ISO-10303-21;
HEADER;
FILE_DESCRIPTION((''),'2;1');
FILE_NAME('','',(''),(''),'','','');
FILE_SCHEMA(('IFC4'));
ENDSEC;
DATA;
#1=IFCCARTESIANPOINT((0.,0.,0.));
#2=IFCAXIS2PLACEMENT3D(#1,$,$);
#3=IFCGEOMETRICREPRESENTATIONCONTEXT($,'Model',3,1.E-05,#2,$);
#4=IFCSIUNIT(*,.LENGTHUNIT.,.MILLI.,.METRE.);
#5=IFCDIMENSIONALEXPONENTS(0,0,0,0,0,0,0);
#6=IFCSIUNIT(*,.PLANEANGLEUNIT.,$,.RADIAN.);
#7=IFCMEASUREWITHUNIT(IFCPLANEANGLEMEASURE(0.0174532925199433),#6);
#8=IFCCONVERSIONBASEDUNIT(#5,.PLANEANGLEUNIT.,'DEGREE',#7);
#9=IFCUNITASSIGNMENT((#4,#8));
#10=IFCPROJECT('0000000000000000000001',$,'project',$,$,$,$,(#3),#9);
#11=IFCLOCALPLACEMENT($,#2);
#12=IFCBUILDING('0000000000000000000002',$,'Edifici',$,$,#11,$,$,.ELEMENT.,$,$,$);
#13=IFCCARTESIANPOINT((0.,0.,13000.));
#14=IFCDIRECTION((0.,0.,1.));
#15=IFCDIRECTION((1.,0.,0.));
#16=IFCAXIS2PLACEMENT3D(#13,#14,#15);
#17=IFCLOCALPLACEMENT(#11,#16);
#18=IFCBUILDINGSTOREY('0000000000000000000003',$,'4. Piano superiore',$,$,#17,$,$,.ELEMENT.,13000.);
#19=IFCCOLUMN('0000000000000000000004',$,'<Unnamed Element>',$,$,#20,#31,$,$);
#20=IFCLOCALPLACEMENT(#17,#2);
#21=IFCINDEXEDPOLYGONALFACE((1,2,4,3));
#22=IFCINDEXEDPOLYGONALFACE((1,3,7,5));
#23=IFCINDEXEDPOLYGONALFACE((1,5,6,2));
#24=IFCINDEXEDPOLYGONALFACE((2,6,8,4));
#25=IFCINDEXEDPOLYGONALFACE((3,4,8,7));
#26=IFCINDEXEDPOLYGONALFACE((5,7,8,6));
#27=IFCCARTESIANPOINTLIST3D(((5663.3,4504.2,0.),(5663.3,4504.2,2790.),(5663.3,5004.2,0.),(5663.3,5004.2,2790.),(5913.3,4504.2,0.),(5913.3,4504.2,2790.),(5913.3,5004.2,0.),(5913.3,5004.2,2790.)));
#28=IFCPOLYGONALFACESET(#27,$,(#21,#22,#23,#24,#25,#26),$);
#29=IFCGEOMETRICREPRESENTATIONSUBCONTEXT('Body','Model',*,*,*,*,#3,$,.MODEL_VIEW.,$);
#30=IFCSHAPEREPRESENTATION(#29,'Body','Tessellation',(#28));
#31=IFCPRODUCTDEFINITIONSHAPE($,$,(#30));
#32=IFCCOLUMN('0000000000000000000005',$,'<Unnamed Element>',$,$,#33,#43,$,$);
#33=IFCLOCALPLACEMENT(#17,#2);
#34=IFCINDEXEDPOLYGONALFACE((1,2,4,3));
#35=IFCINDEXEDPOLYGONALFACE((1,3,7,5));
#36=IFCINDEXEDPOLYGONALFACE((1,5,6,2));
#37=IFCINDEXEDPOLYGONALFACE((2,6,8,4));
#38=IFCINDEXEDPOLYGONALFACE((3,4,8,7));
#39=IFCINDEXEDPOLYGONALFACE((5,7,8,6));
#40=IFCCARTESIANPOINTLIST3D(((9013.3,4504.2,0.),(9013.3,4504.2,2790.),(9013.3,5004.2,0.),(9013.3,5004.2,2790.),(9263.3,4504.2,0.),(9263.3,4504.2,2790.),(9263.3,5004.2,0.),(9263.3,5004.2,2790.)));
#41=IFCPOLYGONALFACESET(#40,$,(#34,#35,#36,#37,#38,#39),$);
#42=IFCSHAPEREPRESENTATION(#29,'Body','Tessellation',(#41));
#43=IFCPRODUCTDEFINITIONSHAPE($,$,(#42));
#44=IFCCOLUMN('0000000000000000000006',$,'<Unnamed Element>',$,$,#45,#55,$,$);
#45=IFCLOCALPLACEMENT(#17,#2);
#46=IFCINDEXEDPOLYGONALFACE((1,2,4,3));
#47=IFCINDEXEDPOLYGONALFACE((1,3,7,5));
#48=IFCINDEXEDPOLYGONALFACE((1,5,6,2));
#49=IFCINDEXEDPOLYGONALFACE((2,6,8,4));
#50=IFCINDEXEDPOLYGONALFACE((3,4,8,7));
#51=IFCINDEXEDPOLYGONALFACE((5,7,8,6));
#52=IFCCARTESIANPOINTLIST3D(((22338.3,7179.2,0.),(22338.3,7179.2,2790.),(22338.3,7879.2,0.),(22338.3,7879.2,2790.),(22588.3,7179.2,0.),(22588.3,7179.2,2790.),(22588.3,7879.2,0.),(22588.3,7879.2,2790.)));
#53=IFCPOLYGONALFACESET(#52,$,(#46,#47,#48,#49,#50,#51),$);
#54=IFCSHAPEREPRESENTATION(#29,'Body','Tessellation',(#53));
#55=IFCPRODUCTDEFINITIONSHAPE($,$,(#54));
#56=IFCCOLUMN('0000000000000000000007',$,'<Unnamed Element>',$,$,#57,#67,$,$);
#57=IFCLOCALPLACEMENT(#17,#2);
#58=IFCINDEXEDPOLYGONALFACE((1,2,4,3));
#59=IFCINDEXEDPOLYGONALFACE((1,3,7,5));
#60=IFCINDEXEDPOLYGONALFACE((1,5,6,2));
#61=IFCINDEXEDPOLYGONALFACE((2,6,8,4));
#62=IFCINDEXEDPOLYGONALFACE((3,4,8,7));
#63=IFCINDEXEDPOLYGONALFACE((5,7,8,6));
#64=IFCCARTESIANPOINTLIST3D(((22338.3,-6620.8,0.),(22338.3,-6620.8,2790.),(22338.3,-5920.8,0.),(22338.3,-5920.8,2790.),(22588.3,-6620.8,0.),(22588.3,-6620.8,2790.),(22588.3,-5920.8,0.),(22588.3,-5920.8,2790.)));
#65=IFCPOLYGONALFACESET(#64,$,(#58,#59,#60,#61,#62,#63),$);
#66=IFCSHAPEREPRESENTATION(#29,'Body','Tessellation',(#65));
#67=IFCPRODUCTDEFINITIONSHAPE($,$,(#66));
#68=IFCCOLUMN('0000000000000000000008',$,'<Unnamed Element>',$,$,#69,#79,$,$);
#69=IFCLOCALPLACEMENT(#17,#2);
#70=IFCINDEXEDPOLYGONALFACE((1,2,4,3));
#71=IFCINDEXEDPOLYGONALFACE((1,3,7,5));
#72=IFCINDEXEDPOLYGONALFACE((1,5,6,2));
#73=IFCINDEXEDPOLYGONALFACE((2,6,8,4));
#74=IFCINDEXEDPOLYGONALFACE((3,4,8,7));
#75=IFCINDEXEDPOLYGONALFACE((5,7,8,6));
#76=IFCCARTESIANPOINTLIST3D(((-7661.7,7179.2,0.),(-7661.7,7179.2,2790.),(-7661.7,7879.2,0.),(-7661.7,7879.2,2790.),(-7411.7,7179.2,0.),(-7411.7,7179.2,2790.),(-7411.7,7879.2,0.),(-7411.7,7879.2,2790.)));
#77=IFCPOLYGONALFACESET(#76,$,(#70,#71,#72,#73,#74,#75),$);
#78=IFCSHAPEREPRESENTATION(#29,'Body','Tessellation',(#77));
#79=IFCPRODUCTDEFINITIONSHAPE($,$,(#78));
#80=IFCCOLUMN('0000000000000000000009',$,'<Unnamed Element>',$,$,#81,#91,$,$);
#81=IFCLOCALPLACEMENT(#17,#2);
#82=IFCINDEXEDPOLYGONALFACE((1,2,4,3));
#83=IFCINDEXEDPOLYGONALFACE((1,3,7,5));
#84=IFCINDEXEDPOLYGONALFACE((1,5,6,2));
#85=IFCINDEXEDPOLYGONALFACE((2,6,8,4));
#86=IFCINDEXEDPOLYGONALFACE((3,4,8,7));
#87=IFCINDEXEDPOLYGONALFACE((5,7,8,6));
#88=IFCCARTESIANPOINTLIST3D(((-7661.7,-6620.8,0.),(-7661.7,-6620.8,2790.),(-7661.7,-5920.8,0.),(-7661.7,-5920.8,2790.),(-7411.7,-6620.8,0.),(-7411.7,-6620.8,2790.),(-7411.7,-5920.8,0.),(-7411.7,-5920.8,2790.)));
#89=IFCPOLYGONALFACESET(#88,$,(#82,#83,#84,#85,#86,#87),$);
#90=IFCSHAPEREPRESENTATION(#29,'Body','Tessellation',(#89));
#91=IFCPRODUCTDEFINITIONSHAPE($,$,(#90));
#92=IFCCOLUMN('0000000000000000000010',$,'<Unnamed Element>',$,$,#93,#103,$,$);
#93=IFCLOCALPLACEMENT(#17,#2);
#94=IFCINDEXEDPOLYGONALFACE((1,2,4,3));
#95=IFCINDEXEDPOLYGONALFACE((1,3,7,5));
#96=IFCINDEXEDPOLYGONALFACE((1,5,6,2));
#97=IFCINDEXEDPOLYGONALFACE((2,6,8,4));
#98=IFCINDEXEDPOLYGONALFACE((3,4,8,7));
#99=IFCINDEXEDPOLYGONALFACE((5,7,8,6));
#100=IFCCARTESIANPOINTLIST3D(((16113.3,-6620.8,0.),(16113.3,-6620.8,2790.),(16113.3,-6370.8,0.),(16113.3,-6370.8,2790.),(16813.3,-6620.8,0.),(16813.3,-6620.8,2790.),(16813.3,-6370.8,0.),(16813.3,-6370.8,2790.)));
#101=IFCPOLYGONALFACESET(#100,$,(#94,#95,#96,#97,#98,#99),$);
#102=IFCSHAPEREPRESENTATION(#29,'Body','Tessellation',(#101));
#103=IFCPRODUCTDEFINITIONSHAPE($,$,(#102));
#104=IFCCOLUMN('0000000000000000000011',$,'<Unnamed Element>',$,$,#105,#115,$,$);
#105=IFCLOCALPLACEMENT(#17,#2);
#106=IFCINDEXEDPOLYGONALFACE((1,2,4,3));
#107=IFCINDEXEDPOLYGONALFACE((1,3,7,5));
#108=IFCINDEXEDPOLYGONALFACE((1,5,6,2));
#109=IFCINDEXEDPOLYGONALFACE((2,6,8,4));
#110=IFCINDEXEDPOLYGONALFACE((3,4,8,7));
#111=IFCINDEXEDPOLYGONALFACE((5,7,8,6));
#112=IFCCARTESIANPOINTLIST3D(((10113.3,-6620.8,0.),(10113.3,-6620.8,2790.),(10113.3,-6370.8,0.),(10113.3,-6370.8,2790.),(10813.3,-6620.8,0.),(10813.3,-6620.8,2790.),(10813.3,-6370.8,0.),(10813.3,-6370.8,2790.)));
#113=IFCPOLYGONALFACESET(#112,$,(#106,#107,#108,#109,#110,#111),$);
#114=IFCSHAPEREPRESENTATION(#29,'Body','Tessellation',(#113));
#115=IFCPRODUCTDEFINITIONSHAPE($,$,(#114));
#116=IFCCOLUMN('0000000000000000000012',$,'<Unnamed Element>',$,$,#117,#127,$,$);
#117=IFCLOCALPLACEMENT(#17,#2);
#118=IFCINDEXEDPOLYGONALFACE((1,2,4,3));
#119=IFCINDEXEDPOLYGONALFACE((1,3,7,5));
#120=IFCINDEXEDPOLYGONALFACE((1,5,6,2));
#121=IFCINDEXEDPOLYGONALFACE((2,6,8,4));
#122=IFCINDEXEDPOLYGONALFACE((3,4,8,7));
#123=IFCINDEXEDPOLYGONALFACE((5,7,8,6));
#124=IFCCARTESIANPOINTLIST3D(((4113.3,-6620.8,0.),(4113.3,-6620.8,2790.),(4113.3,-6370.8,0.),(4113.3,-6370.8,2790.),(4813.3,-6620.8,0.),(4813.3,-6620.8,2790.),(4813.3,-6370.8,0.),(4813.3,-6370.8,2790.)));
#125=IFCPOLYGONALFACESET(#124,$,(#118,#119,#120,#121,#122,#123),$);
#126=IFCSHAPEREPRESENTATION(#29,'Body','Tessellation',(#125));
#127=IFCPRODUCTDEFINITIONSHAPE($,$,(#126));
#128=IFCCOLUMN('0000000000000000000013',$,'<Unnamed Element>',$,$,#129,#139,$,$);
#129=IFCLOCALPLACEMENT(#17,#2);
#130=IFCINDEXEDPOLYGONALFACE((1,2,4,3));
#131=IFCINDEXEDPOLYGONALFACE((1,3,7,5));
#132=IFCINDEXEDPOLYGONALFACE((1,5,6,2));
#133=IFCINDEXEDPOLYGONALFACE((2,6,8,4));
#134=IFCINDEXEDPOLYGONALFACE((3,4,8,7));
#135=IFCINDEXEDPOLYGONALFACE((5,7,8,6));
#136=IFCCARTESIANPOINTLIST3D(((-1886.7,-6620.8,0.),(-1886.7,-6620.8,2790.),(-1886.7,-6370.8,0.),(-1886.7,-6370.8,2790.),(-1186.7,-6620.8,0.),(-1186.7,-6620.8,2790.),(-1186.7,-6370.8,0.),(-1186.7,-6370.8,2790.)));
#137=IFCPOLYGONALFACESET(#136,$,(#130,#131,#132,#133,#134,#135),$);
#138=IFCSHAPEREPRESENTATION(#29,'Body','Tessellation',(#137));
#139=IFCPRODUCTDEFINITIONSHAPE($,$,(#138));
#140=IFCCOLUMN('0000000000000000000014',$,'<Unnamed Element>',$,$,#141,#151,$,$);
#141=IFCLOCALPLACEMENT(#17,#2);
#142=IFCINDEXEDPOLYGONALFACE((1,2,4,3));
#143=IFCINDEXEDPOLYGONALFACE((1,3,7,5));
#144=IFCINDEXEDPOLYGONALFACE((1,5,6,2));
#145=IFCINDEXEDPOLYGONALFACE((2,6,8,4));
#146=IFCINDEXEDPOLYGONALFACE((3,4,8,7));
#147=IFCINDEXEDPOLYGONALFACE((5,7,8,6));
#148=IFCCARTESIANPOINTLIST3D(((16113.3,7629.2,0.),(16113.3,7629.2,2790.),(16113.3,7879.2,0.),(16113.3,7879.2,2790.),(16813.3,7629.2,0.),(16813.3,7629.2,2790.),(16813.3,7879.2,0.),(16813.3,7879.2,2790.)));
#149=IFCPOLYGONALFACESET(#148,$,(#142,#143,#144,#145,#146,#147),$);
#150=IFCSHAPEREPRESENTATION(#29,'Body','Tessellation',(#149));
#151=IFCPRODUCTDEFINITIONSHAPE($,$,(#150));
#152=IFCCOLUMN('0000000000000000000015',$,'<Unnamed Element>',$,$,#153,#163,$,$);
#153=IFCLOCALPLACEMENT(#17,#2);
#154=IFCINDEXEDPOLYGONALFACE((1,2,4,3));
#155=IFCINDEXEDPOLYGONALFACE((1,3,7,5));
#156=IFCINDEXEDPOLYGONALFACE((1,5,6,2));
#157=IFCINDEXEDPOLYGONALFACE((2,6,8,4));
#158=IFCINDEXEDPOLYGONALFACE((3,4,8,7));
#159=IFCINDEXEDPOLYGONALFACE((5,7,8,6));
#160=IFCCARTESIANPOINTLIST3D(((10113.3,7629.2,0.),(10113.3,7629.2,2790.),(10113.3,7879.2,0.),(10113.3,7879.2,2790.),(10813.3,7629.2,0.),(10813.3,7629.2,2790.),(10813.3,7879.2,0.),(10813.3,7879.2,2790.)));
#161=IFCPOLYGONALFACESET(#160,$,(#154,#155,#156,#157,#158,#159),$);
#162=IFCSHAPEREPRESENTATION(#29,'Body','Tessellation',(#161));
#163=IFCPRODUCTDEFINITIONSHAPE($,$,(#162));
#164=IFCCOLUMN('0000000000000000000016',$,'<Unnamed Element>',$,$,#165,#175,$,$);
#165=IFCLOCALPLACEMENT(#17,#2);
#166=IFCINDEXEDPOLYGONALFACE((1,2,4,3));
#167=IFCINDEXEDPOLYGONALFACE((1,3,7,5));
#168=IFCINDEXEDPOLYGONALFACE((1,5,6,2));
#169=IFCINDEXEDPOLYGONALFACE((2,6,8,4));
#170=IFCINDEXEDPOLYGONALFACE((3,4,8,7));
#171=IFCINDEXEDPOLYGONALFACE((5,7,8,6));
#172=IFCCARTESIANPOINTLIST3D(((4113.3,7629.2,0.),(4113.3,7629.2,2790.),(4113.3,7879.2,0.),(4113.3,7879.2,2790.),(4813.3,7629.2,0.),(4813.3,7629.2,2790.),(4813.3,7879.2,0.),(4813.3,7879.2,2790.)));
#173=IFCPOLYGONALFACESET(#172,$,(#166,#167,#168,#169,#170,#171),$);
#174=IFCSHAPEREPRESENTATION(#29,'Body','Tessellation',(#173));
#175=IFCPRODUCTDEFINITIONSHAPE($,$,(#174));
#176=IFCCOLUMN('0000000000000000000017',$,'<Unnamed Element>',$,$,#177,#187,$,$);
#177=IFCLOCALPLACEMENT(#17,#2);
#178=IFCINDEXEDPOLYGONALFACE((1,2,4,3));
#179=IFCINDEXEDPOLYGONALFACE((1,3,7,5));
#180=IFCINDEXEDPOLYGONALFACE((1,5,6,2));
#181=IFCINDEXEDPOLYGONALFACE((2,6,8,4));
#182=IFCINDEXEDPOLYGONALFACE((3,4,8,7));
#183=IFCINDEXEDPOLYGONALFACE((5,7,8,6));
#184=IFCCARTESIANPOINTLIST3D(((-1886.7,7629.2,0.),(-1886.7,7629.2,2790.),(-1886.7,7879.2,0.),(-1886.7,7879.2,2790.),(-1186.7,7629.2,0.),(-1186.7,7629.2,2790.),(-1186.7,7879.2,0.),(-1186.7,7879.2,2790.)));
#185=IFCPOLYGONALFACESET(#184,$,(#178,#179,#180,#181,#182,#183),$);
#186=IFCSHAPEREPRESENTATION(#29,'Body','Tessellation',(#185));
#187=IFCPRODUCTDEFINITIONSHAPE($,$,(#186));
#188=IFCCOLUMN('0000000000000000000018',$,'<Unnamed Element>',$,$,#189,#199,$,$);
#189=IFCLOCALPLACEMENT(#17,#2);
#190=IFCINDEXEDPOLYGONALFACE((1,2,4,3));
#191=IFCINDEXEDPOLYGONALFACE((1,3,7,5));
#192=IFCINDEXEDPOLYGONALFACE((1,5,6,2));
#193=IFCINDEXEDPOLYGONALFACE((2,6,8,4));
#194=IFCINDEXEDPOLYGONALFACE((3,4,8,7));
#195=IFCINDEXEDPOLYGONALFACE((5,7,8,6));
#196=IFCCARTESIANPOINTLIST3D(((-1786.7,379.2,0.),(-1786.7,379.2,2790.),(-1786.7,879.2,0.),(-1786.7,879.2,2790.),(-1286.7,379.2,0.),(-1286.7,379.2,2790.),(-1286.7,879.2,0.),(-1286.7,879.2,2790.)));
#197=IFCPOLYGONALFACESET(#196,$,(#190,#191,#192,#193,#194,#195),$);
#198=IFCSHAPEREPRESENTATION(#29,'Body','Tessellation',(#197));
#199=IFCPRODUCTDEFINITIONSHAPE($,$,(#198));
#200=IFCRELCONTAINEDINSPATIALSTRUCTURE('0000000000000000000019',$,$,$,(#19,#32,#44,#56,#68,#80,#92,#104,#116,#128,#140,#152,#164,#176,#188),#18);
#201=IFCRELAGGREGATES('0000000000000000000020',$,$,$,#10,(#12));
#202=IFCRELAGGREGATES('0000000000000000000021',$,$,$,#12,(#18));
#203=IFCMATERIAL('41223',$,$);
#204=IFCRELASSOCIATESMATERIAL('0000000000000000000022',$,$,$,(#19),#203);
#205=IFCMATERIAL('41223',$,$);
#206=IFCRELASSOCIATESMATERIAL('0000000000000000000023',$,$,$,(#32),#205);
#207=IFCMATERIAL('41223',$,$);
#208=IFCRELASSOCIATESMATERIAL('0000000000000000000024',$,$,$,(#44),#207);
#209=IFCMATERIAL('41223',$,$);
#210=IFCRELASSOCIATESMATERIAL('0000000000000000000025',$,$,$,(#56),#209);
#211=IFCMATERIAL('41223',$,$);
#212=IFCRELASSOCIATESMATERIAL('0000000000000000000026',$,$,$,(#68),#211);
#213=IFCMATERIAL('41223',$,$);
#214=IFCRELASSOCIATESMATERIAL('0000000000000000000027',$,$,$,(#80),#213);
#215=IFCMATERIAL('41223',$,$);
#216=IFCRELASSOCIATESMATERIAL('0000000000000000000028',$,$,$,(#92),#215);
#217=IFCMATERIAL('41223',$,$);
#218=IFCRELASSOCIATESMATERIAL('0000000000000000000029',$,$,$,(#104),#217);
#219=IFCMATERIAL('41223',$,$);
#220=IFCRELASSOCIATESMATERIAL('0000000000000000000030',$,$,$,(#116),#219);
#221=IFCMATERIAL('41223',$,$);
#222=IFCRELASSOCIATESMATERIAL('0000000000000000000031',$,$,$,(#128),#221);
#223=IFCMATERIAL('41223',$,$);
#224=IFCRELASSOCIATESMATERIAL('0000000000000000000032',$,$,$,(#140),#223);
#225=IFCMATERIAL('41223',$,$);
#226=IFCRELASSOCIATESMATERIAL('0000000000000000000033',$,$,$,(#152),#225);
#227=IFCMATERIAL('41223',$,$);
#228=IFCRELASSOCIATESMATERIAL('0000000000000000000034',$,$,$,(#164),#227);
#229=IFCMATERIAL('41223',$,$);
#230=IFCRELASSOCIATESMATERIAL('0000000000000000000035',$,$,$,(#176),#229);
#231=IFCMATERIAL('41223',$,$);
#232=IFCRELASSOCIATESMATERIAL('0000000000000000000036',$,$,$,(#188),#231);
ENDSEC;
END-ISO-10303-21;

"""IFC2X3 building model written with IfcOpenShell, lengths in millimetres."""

from ifc_helpers import new_model, entity, si_unit, converted_unit, frame, frame_2d, origin, origin_with_axes, place, context, subcontext, project, spatial, rectangle, extrude, material, element, save


model = new_model("IFC2X3")

# Units and contexts
model_context = context("Model", 3, precision=1e-05, world=origin())
body_context = subcontext(model_context, "Body", "Model", "MODEL_VIEW")
ifc_project = project(units=[si_unit("LENGTHUNIT", "METRE", prefix="MILLI"), converted_unit("PLANEANGLEUNIT", "DEGREE", entity("IfcPlaneAngleMeasure", 0.0174532925199433), si_unit("PLANEANGLEUNIT", "RADIAN"), dimensions=[0, 0, 0, 0, 0, 0, 0])], contexts=[model_context])

# Building, storey
building_placement = place(None, origin())
building = spatial("IfcBuilding", under=ifc_project, at=building_placement, Name="Edifici", CompositionType="ELEMENT")
storey_placement = place(building_placement, frame((0.0, 0.0, 13000.0), z_axis=(0.0, 0.0, 1.0), x_axis=(1.0, 0.0, 0.0)))
storey = spatial("IfcBuildingStorey", under=building, at=storey_placement, Name="4. Piano superiore", CompositionType="ELEMENT", Elevation=13000.0)

# Columns
ifc_material_1 = material(Name="41223")
column_1_placement = place(storey_placement, frame((5913.3, 5004.2, 0.0), z_axis=(0.0, 0.0, 1.0), x_axis=(1.0, 0.0, 0.0)))
element("IfcColumn", 1, at=column_1_placement, inside=storey, material=ifc_material_1, Name="<Unnamed Element>", context=body_context, shape_type="SweptSolid", body=[
    extrude(rectangle(XDim=250.0, YDim=500.0, at=frame_2d((-125.0, -250.0), x_axis=(-1.0, 0.0))), origin_with_axes(), (0.0, 0.0, 1.0), 2790.0),
])
ifc_material_2 = material(Name="41223")
column_2_placement = place(storey_placement, frame((9263.3, 5004.2, 0.0), z_axis=(0.0, 0.0, 1.0), x_axis=(1.0, 0.0, 0.0)))
element("IfcColumn", 2, at=column_2_placement, inside=storey, material=ifc_material_2, Name="<Unnamed Element>", context=body_context, shape_type="SweptSolid", body=[
    extrude(rectangle(XDim=250.0, YDim=500.0, at=frame_2d((-125.0, -250.0), x_axis=(-1.0, 0.0))), origin_with_axes(), (0.0, 0.0, 1.0), 2790.0),
])
ifc_material_3 = material(Name="41223")
column_3_placement = place(storey_placement, frame((22588.3, 7879.2, 0.0), z_axis=(0.0, 0.0, 1.0), x_axis=(1.0, 0.0, 0.0)))
element("IfcColumn", 3, at=column_3_placement, inside=storey, material=ifc_material_3, Name="<Unnamed Element>", context=body_context, shape_type="SweptSolid", body=[
    extrude(rectangle(XDim=250.0, YDim=700.0, at=frame_2d((-125.0, -350.0), x_axis=(-1.0, 0.0))), origin_with_axes(), (0.0, 0.0, 1.0), 2790.0),
])
ifc_material_4 = material(Name="41223")
column_4_placement = place(storey_placement, frame((22588.3, -5920.8, 0.0), z_axis=(0.0, 0.0, 1.0), x_axis=(1.0, 0.0, 0.0)))
element("IfcColumn", 4, at=column_4_placement, inside=storey, material=ifc_material_4, Name="<Unnamed Element>", context=body_context, shape_type="SweptSolid", body=[
    extrude(rectangle(XDim=250.0, YDim=700.0, at=frame_2d((-125.0, -350.0), x_axis=(-1.0, 0.0))), origin_with_axes(), (0.0, 0.0, 1.0), 2790.0),
])
ifc_material_5 = material(Name="41223")
column_5_placement = place(storey_placement, frame((-7411.7, 7879.2, 0.0), z_axis=(0.0, 0.0, 1.0), x_axis=(1.0, 0.0, 0.0)))
element("IfcColumn", 5, at=column_5_placement, inside=storey, material=ifc_material_5, Name="<Unnamed Element>", context=body_context, shape_type="SweptSolid", body=[
    extrude(rectangle(XDim=250.0, YDim=700.0, at=frame_2d((-125.0, -350.0), x_axis=(-1.0, 0.0))), origin_with_axes(), (0.0, 0.0, 1.0), 2790.0),
])
ifc_material_6 = material(Name="41223")
column_6_placement = place(storey_placement, frame((-7411.7, -5920.8, 0.0), z_axis=(0.0, 0.0, 1.0), x_axis=(1.0, 0.0, 0.0)))
element("IfcColumn", 6, at=column_6_placement, inside=storey, material=ifc_material_6, Name="<Unnamed Element>", context=body_context, shape_type="SweptSolid", body=[
    extrude(rectangle(XDim=250.0, YDim=700.0, at=frame_2d((-125.0, -350.0), x_axis=(-1.0, 0.0))), origin_with_axes(), (0.0, 0.0, 1.0), 2790.0),
])
ifc_material_7 = material(Name="41223")
column_7_placement = place(storey_placement, frame((16813.3, -6620.8, 0.0), z_axis=(0.0, 0.0, 1.0), x_axis=(1.0, 0.0, 0.0)))
element("IfcColumn", 7, at=column_7_placement, inside=storey, material=ifc_material_7, Name="<Unnamed Element>", context=body_context, shape_type="SweptSolid", body=[
    extrude(rectangle(XDim=250.0, YDim=700.0, at=frame_2d((-350.0, 125.0), x_axis=(0.0, 1.0))), origin_with_axes(), (0.0, 0.0, 1.0), 2790.0),
])
ifc_material_8 = material(Name="41223")
column_8_placement = place(storey_placement, frame((10813.3, -6620.8, 0.0), z_axis=(0.0, 0.0, 1.0), x_axis=(1.0, 0.0, 0.0)))
element("IfcColumn", 8, at=column_8_placement, inside=storey, material=ifc_material_8, Name="<Unnamed Element>", context=body_context, shape_type="SweptSolid", body=[
    extrude(rectangle(XDim=250.0, YDim=700.0, at=frame_2d((-350.0, 125.0), x_axis=(0.0, 1.0))), origin_with_axes(), (0.0, 0.0, 1.0), 2790.0),
])
ifc_material_9 = material(Name="41223")
column_9_placement = place(storey_placement, frame((4813.3, -6620.8, 0.0), z_axis=(0.0, 0.0, 1.0), x_axis=(1.0, 0.0, 0.0)))
element("IfcColumn", 9, at=column_9_placement, inside=storey, material=ifc_material_9, Name="<Unnamed Element>", context=body_context, shape_type="SweptSolid", body=[
    extrude(rectangle(XDim=250.0, YDim=700.0, at=frame_2d((-350.0, 125.0), x_axis=(0.0, 1.0))), origin_with_axes(), (0.0, 0.0, 1.0), 2790.0),
])
ifc_material_10 = material(Name="41223")
column_10_placement = place(storey_placement, frame((-1186.7, -6620.8, 0.0), z_axis=(0.0, 0.0, 1.0), x_axis=(1.0, 0.0, 0.0)))
element("IfcColumn", 10, at=column_10_placement, inside=storey, material=ifc_material_10, Name="<Unnamed Element>", context=body_context, shape_type="SweptSolid", body=[
    extrude(rectangle(XDim=250.0, YDim=700.0, at=frame_2d((-350.0, 125.0), x_axis=(0.0, 1.0))), origin_with_axes(), (0.0, 0.0, 1.0), 2790.0),
])
ifc_material_11 = material(Name="41223")
column_11_placement = place(storey_placement, frame((16813.3, 7629.2, 0.0), z_axis=(0.0, 0.0, 1.0), x_axis=(1.0, 0.0, 0.0)))
element("IfcColumn", 11, at=column_11_placement, inside=storey, material=ifc_material_11, Name="<Unnamed Element>", context=body_context, shape_type="SweptSolid", body=[
    extrude(rectangle(XDim=250.0, YDim=700.0, at=frame_2d((-350.0, 125.0), x_axis=(0.0, 1.0))), origin_with_axes(), (0.0, 0.0, 1.0), 2790.0),
])
ifc_material_12 = material(Name="41223")
column_12_placement = place(storey_placement, frame((10813.3, 7629.2, 0.0), z_axis=(0.0, 0.0, 1.0), x_axis=(1.0, 0.0, 0.0)))
element("IfcColumn", 12, at=column_12_placement, inside=storey, material=ifc_material_12, Name="<Unnamed Element>", context=body_context, shape_type="SweptSolid", body=[
    extrude(rectangle(XDim=250.0, YDim=700.0, at=frame_2d((-350.0, 125.0), x_axis=(0.0, 1.0))), origin_with_axes(), (0.0, 0.0, 1.0), 2790.0),
])
ifc_material_13 = material(Name="41223")
column_13_placement = place(storey_placement, frame((4813.3, 7629.2, 0.0), z_axis=(0.0, 0.0, 1.0), x_axis=(1.0, 0.0, 0.0)))
element("IfcColumn", 13, at=column_13_placement, inside=storey, material=ifc_material_13, Name="<Unnamed Element>", context=body_context, shape_type="SweptSolid", body=[
    extrude(rectangle(XDim=250.0, YDim=700.0, at=frame_2d((-350.0, 125.0), x_axis=(0.0, 1.0))), origin_with_axes(), (0.0, 0.0, 1.0), 2790.0),
])
ifc_material_14 = material(Name="41223")
column_14_placement = place(storey_placement, frame((-1186.7, 7629.2, 0.0), z_axis=(0.0, 0.0, 1.0), x_axis=(1.0, 0.0, 0.0)))
element("IfcColumn", 14, at=column_14_placement, inside=storey, material=ifc_material_14, Name="<Unnamed Element>", context=body_context, shape_type="SweptSolid", body=[
    extrude(rectangle(XDim=250.0, YDim=700.0, at=frame_2d((-350.0, 125.0), x_axis=(0.0, 1.0))), origin_with_axes(), (0.0, 0.0, 1.0), 2790.0),
])
ifc_material_15 = material(Name="41223")
column_15_placement = place(storey_placement, frame((-1786.7, 379.2, 0.0), z_axis=(0.0, 0.0, 1.0), x_axis=(1.0, 0.0, 0.0)))
element("IfcColumn", 15, at=column_15_placement, inside=storey, material=ifc_material_15, Name="<Unnamed Element>", context=body_context, shape_type="SweptSolid", body=[
    extrude(rectangle(XDim=500.0, YDim=500.0, at=frame_2d((250.0, 250.0), x_axis=(1.0, 0.0))), origin_with_axes(), (0.0, 0.0, 1.0), 2790.0),
])

save(model, "model.ifc")
